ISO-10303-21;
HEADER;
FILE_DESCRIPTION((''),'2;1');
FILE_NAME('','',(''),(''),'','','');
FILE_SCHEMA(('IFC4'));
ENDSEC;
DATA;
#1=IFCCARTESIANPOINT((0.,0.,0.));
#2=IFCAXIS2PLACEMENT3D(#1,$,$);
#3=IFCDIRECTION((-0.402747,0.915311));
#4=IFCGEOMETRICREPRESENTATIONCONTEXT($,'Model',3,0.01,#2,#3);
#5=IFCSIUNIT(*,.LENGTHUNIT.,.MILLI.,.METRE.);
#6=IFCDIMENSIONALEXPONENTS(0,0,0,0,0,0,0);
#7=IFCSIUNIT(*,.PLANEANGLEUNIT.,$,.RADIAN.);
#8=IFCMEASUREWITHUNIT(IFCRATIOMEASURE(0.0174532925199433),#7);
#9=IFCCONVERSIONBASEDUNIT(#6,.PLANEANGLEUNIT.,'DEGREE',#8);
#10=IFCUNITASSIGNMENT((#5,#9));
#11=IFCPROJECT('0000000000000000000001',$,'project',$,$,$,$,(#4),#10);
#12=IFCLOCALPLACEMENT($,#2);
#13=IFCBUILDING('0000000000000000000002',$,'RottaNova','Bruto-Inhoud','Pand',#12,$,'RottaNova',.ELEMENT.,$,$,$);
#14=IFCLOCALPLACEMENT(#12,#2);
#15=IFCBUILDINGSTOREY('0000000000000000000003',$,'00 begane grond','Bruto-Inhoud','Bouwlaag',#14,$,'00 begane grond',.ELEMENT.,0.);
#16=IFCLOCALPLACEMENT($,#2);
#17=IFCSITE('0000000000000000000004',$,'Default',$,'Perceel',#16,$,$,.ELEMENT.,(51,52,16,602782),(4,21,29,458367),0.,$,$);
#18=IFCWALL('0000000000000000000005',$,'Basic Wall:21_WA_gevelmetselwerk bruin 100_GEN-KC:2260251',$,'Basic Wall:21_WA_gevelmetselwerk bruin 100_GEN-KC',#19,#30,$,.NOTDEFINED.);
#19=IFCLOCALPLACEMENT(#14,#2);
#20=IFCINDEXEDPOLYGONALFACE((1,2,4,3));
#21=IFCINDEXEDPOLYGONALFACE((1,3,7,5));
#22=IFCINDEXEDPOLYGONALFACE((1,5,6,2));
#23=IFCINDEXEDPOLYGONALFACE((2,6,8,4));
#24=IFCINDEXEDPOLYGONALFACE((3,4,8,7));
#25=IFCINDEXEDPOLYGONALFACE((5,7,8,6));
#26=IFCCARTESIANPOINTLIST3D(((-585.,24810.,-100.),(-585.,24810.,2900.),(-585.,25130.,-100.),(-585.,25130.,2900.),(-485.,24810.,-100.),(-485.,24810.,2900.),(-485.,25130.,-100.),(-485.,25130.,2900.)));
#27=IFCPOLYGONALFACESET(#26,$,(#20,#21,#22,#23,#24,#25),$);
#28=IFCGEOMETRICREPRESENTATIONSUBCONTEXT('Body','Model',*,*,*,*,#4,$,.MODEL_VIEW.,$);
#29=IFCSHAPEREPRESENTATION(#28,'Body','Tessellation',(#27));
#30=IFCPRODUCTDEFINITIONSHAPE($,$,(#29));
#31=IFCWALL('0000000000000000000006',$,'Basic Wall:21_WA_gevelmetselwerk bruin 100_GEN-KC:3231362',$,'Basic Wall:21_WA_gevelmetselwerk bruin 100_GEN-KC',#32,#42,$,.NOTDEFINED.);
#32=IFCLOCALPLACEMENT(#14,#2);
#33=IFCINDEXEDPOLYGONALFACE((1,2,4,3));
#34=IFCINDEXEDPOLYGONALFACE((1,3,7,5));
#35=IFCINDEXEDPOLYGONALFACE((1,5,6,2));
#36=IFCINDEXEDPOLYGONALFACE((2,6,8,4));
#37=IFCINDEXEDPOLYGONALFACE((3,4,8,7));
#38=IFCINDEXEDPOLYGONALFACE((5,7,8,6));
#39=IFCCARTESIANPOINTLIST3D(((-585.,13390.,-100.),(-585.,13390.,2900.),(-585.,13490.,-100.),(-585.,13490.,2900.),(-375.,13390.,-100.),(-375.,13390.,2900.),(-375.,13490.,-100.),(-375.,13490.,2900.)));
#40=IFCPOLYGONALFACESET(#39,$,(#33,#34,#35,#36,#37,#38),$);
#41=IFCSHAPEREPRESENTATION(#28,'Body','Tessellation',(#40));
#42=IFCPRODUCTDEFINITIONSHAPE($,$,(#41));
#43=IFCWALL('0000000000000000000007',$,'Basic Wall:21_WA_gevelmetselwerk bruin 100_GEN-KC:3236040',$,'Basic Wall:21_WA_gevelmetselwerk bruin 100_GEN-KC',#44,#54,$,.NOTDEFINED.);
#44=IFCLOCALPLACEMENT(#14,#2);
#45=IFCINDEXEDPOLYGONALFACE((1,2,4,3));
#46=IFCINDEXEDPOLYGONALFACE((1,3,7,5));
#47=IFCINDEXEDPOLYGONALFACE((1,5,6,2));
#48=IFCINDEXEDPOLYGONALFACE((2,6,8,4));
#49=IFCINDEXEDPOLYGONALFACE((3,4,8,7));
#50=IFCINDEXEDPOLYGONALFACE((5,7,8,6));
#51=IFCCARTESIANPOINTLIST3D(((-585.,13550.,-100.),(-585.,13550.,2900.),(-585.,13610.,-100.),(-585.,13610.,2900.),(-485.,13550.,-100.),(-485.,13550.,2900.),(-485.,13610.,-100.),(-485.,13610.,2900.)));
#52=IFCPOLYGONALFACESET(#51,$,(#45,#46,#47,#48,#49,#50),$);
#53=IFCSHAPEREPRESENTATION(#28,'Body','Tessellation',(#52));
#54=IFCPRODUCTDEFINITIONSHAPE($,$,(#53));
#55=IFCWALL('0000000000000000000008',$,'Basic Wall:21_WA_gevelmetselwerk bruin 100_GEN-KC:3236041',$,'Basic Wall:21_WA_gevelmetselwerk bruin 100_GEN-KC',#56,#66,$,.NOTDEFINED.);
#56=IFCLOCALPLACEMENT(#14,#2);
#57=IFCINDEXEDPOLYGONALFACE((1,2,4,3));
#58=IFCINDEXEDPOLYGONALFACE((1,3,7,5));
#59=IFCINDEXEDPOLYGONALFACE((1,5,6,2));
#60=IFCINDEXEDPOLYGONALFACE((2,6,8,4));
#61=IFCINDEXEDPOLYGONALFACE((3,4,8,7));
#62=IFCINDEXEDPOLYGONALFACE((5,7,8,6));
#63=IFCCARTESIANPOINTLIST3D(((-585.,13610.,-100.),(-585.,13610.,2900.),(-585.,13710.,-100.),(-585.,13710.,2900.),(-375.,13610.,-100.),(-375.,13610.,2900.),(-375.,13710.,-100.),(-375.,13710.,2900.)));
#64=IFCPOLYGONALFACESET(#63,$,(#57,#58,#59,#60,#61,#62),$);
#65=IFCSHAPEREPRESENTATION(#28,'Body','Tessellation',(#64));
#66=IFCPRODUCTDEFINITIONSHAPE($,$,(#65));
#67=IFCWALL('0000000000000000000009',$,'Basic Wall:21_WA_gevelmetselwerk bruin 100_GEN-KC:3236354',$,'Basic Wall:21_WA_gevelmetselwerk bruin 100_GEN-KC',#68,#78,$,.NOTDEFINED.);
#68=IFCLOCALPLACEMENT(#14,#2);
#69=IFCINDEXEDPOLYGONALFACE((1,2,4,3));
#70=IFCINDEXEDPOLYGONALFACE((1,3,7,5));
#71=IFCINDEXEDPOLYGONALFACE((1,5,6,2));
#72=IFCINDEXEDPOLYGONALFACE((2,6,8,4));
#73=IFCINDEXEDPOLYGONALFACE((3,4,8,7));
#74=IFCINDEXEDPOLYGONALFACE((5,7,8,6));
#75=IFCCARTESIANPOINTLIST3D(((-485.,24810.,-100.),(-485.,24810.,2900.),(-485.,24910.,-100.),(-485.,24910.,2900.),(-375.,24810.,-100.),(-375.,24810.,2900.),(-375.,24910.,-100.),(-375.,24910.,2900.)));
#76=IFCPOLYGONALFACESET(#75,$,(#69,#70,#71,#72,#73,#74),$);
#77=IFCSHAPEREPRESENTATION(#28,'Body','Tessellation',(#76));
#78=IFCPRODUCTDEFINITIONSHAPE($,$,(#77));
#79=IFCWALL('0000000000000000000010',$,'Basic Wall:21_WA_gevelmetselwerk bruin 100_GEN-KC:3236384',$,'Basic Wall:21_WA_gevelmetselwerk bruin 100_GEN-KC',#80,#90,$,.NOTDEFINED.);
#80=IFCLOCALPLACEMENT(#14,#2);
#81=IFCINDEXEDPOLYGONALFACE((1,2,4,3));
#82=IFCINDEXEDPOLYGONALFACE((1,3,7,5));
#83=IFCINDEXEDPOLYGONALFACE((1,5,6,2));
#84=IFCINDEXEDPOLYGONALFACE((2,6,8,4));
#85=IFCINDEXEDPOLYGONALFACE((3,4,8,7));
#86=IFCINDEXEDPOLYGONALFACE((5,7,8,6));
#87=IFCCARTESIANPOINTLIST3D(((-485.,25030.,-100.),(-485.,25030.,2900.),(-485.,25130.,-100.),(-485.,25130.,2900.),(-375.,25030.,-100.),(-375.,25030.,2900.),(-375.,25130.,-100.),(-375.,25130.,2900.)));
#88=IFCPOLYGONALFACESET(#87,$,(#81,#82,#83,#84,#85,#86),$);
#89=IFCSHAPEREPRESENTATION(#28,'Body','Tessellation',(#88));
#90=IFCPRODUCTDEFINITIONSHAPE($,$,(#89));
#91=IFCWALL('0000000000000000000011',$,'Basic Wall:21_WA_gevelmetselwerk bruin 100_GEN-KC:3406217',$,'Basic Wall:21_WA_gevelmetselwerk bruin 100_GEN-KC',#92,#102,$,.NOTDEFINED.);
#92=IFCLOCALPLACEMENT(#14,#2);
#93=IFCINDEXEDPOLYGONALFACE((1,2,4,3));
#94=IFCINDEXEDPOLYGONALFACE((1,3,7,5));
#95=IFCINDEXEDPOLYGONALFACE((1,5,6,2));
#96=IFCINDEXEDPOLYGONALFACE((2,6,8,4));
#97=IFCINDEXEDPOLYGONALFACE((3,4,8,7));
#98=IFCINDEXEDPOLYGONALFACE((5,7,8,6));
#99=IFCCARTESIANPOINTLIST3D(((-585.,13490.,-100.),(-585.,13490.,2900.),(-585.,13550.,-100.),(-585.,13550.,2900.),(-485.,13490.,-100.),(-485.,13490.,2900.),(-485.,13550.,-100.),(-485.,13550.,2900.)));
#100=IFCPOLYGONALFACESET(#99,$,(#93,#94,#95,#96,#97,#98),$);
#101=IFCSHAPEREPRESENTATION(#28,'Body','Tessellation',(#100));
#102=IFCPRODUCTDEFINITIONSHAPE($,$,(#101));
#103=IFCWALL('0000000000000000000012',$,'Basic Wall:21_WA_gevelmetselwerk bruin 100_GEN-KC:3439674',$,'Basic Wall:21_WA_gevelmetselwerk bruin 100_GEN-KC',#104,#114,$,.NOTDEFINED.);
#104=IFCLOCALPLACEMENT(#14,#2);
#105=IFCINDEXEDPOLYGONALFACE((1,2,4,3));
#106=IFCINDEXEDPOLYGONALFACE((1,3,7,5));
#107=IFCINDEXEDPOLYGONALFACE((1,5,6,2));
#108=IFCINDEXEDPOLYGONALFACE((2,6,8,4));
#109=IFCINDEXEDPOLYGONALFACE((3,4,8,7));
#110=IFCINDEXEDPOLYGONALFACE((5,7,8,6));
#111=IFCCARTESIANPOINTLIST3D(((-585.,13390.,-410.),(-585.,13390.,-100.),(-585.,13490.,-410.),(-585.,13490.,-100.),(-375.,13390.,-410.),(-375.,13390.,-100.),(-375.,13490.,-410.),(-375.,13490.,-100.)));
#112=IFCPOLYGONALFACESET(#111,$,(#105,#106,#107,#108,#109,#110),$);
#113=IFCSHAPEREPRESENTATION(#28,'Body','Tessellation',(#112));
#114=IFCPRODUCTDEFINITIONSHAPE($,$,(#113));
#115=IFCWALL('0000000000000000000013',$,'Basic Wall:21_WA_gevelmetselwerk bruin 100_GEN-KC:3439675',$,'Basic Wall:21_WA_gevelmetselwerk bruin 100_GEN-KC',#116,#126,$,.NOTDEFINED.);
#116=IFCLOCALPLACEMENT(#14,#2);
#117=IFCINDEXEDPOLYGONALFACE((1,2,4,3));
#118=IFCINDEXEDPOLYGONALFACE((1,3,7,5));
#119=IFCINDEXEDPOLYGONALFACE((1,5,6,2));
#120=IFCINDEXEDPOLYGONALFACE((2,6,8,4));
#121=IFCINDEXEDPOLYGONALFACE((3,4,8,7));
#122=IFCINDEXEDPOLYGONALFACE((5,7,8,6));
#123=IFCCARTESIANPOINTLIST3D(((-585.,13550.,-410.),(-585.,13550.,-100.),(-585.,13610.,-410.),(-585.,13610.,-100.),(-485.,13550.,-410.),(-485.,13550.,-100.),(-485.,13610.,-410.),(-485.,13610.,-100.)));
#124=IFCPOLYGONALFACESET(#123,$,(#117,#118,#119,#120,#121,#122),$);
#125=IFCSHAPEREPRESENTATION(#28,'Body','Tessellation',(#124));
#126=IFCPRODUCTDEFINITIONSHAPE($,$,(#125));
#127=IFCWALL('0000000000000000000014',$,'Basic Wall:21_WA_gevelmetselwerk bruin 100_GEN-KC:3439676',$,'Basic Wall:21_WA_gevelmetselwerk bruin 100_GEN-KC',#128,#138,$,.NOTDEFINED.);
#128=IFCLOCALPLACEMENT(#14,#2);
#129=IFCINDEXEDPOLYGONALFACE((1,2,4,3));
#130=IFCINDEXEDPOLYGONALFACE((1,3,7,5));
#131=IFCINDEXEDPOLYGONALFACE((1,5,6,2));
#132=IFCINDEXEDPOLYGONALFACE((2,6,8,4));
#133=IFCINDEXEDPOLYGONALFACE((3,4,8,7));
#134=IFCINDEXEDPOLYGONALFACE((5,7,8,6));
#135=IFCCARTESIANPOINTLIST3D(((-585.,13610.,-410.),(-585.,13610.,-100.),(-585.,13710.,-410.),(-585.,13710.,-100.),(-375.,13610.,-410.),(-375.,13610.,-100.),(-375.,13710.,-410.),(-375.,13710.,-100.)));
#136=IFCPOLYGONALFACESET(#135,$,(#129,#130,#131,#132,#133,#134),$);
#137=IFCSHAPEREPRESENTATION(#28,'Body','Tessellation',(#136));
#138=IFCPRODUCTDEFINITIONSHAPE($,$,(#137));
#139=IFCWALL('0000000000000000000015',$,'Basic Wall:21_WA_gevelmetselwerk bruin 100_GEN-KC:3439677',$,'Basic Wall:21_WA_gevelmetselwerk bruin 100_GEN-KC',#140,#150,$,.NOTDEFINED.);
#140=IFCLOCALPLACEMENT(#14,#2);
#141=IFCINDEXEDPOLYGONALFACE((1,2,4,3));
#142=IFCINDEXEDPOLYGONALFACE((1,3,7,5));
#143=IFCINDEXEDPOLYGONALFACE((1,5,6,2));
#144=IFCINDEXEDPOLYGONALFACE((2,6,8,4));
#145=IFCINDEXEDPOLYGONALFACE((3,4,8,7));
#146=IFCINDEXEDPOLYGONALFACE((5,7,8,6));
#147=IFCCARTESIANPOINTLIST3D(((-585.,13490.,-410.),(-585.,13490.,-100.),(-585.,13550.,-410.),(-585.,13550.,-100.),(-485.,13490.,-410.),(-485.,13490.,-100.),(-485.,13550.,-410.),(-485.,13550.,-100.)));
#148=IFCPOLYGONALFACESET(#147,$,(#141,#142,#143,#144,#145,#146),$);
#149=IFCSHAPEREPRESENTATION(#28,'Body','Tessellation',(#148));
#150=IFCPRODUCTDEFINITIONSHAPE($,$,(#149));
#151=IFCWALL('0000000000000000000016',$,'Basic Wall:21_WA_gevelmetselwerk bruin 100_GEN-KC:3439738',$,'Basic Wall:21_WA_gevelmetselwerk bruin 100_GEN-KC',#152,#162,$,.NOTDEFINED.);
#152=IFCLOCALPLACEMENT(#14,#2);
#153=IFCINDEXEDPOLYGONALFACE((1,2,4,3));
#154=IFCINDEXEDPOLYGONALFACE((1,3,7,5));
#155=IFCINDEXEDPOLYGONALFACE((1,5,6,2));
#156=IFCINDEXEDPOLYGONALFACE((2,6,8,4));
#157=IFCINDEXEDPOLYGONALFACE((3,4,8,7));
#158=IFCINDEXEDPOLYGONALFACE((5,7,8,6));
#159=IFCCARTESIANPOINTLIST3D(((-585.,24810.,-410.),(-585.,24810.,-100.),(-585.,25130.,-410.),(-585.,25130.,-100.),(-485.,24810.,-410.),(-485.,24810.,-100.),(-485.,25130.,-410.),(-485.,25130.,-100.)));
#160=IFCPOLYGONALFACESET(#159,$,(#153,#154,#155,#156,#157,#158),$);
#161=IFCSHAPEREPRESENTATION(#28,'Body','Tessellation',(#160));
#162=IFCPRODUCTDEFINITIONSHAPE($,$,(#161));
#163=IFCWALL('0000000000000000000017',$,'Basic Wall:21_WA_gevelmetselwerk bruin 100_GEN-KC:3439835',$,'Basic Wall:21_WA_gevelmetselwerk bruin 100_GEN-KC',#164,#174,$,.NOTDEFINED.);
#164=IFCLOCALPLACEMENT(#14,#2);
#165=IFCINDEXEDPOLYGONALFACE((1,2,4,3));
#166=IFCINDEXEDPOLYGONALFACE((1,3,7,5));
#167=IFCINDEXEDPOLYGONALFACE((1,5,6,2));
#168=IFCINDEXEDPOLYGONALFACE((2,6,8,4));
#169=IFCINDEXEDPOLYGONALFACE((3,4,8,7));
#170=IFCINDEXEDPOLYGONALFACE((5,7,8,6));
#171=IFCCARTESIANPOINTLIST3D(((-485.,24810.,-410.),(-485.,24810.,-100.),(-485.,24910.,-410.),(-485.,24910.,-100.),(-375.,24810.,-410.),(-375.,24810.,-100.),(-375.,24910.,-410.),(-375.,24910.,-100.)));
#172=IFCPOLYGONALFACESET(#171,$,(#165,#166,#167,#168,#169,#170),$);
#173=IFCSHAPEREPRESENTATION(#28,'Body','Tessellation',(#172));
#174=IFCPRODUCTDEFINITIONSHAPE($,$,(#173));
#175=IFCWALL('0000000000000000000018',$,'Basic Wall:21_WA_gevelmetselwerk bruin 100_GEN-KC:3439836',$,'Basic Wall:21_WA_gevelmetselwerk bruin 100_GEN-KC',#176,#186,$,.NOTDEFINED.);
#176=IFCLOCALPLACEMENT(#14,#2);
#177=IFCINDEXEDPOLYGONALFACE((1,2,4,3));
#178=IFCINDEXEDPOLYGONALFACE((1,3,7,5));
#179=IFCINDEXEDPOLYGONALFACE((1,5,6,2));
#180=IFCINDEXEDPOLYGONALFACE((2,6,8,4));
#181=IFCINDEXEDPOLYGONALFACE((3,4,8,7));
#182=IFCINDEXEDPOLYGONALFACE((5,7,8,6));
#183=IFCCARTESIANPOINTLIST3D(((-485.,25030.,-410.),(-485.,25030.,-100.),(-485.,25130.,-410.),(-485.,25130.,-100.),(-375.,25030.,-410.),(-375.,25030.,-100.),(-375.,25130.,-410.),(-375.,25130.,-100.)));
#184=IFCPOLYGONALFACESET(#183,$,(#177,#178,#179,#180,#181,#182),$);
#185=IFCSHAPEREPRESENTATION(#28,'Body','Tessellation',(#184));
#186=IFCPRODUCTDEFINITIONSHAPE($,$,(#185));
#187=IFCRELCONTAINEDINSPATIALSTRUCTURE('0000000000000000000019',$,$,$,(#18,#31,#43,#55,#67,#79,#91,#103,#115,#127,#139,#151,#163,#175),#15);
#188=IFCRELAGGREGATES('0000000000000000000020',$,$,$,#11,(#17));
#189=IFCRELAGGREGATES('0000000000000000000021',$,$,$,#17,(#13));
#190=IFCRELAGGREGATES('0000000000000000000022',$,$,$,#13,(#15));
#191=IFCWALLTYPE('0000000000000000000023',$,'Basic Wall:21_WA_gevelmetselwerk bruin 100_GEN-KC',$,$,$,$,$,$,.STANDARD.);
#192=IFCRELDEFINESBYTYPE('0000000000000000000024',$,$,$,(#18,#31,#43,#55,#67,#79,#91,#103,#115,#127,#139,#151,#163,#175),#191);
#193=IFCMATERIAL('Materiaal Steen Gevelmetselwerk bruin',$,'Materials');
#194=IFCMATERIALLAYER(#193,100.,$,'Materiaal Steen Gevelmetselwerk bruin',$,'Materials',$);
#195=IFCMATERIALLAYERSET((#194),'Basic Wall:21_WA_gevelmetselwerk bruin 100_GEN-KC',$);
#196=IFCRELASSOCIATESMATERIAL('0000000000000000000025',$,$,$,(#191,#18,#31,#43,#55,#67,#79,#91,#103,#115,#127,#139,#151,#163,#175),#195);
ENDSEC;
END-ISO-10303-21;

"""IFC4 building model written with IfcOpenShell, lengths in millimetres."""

from ifc_helpers import new_model, entity, si_unit, converted_unit, direction, frame, frame_2d, origin, place, context, subcontext, project, spatial, rectangle, extrude, material, layer, layer_set, type_object, element, save


model = new_model("IFC4")

# Units and contexts
model_context = context("Model", 3, precision=0.01, world=origin(), true_north=direction((-0.402747, 0.915311)))
body_context = subcontext(model_context, "Body", "Model", "MODEL_VIEW")
ifc_project = project(units=[si_unit("LENGTHUNIT", "METRE", prefix="MILLI"), converted_unit("PLANEANGLEUNIT", "DEGREE", entity("IfcRatioMeasure", 0.0174532925199433), si_unit("PLANEANGLEUNIT", "RADIAN"), dimensions=[0, 0, 0, 0, 0, 0, 0])], contexts=[model_context])

# Site, building, storey
site_placement = place(None, origin())
site = spatial("IfcSite", under=ifc_project, at=site_placement, Name="Default", ObjectType="Perceel", CompositionType="ELEMENT", RefLatitude=(51, 52, 16, 602782), RefLongitude=(4, 21, 29, 458367), RefElevation=0.0)
building_placement = place(None, origin())
building = spatial("IfcBuilding", under=site, at=building_placement, Name="RottaNova", Description="Bruto-Inhoud", ObjectType="Pand", LongName="RottaNova", CompositionType="ELEMENT")
storey_placement = place(building_placement, origin())
storey = spatial("IfcBuildingStorey", under=building, at=storey_placement, Name="00 begane grond", Description="Bruto-Inhoud", ObjectType="Bouwlaag", LongName="00 begane grond", CompositionType="ELEMENT", Elevation=0.0)

# Walls
ifc_material_1 = material(Name="Materiaal Steen Gevelmetselwerk bruin", Category="Materials")
ifc_layer_1 = layer(ifc_material_1, 100.0, Name="Materiaal Steen Gevelmetselwerk bruin", Category="Materials")
ifc_layer_set_1 = layer_set([ifc_layer_1], Name="Basic Wall:21_WA_gevelmetselwerk bruin 100_GEN-KC")
wall_type_1 = type_object("IfcWallType", Name="Basic Wall:21_WA_gevelmetselwerk bruin 100_GEN-KC", PredefinedType="STANDARD", material=ifc_layer_set_1)
wall_1_placement = place(storey_placement, frame((-535.0, 25130.0, -100.0), z_axis=(0.0, 0.0, 1.0), x_axis=(0.0, -1.0, 0.0)))
element("IfcWall", 1, at=wall_1_placement, inside=storey, type_object=wall_type_1, material=ifc_layer_set_1, Name="Basic Wall:21_WA_gevelmetselwerk bruin 100_GEN-KC:2260251", ObjectType="Basic Wall:21_WA_gevelmetselwerk bruin 100_GEN-KC", PredefinedType="NOTDEFINED", context=body_context, shape_type="SweptSolid", body=[
    extrude(rectangle(XDim=320.0, YDim=100.0, at=frame_2d((160.0, 0.0), x_axis=(-1.0, 0.0))), origin(), (0.0, 0.0, 1.0), 3000.0),
])
wall_2_placement = place(storey_placement, frame((-585.0, 13440.0, -100.0)))
element("IfcWall", 2, at=wall_2_placement, inside=storey, type_object=wall_type_1, material=ifc_layer_set_1, Name="Basic Wall:21_WA_gevelmetselwerk bruin 100_GEN-KC:3231362", ObjectType="Basic Wall:21_WA_gevelmetselwerk bruin 100_GEN-KC", PredefinedType="NOTDEFINED", context=body_context, shape_type="SweptSolid", body=[
    extrude(rectangle(XDim=210.0, YDim=100.0, at=frame_2d((105.0, 0.0), x_axis=(-1.0, 0.0))), origin(), (0.0, 0.0, 1.0), 3000.0),
])
wall_3_placement = place(storey_placement, frame((-535.0, 13550.0, -100.0), z_axis=(0.0, 0.0, 1.0), x_axis=(0.0, 1.0, 0.0)))
element("IfcWall", 3, at=wall_3_placement, inside=storey, type_object=wall_type_1, material=ifc_layer_set_1, Name="Basic Wall:21_WA_gevelmetselwerk bruin 100_GEN-KC:3236040", ObjectType="Basic Wall:21_WA_gevelmetselwerk bruin 100_GEN-KC", PredefinedType="NOTDEFINED", context=body_context, shape_type="SweptSolid", body=[
    extrude(rectangle(XDim=60.0, YDim=100.0, at=frame_2d((30.0, 0.0), x_axis=(-1.0, 0.0))), origin(), (0.0, 0.0, 1.0), 3000.0),
])
wall_4_placement = place(storey_placement, frame((-585.0, 13660.0, -100.0)))
element("IfcWall", 4, at=wall_4_placement, inside=storey, type_object=wall_type_1, material=ifc_layer_set_1, Name="Basic Wall:21_WA_gevelmetselwerk bruin 100_GEN-KC:3236041", ObjectType="Basic Wall:21_WA_gevelmetselwerk bruin 100_GEN-KC", PredefinedType="NOTDEFINED", context=body_context, shape_type="SweptSolid", body=[
    extrude(rectangle(XDim=210.0, YDim=100.0, at=frame_2d((105.0, 0.0), x_axis=(-1.0, 0.0))), origin(), (0.0, 0.0, 1.0), 3000.0),
])
wall_5_placement = place(storey_placement, frame((-485.0, 24860.0, -100.0)))
element("IfcWall", 5, at=wall_5_placement, inside=storey, type_object=wall_type_1, material=ifc_layer_set_1, Name="Basic Wall:21_WA_gevelmetselwerk bruin 100_GEN-KC:3236354", ObjectType="Basic Wall:21_WA_gevelmetselwerk bruin 100_GEN-KC", PredefinedType="NOTDEFINED", context=body_context, shape_type="SweptSolid", body=[
    extrude(rectangle(XDim=110.0, YDim=100.0, at=frame_2d((55.0, 0.0), x_axis=(-1.0, 0.0))), origin(), (0.0, 0.0, 1.0), 3000.0),
])
wall_6_placement = place(storey_placement, frame((-485.0, 25080.0, -100.0)))
element("IfcWall", 6, at=wall_6_placement, inside=storey, type_object=wall_type_1, material=ifc_layer_set_1, Name="Basic Wall:21_WA_gevelmetselwerk bruin 100_GEN-KC:3236384", ObjectType="Basic Wall:21_WA_gevelmetselwerk bruin 100_GEN-KC", PredefinedType="NOTDEFINED", context=body_context, shape_type="SweptSolid", body=[
    extrude(rectangle(XDim=110.0, YDim=100.0, at=frame_2d((55.0, 0.0), x_axis=(-1.0, 0.0))), origin(), (0.0, 0.0, 1.0), 3000.0),
])
wall_7_placement = place(storey_placement, frame((-535.0, 13490.0, -100.0), z_axis=(0.0, 0.0, 1.0), x_axis=(0.0, 1.0, 0.0)))
element("IfcWall", 7, at=wall_7_placement, inside=storey, type_object=wall_type_1, material=ifc_layer_set_1, Name="Basic Wall:21_WA_gevelmetselwerk bruin 100_GEN-KC:3406217", ObjectType="Basic Wall:21_WA_gevelmetselwerk bruin 100_GEN-KC", PredefinedType="NOTDEFINED", context=body_context, shape_type="SweptSolid", body=[
    extrude(rectangle(XDim=60.0, YDim=100.0, at=frame_2d((30.0, 0.0), x_axis=(-1.0, 0.0))), origin(), (0.0, 0.0, 1.0), 3000.0),
])
wall_8_placement = place(storey_placement, frame((-585.0, 13440.0, -410.0)))
element("IfcWall", 8, at=wall_8_placement, inside=storey, type_object=wall_type_1, material=ifc_layer_set_1, Name="Basic Wall:21_WA_gevelmetselwerk bruin 100_GEN-KC:3439674", ObjectType="Basic Wall:21_WA_gevelmetselwerk bruin 100_GEN-KC", PredefinedType="NOTDEFINED", context=body_context, shape_type="SweptSolid", body=[
    extrude(rectangle(XDim=210.0, YDim=100.0, at=frame_2d((105.0, 0.0), x_axis=(-1.0, 0.0))), origin(), (0.0, 0.0, 1.0), 310.0),
])
wall_9_placement = place(storey_placement, frame((-535.0, 13550.0, -410.0), z_axis=(0.0, 0.0, 1.0), x_axis=(0.0, 1.0, 0.0)))
element("IfcWall", 9, at=wall_9_placement, inside=storey, type_object=wall_type_1, material=ifc_layer_set_1, Name="Basic Wall:21_WA_gevelmetselwerk bruin 100_GEN-KC:3439675", ObjectType="Basic Wall:21_WA_gevelmetselwerk bruin 100_GEN-KC", PredefinedType="NOTDEFINED", context=body_context, shape_type="SweptSolid", body=[
    extrude(rectangle(XDim=60.0, YDim=100.0, at=frame_2d((30.0, 0.0), x_axis=(-1.0, 0.0))), origin(), (0.0, 0.0, 1.0), 310.0),
])
wall_10_placement = place(storey_placement, frame((-585.0, 13660.0, -410.0)))
element("IfcWall", 10, at=wall_10_placement, inside=storey, type_object=wall_type_1, material=ifc_layer_set_1, Name="Basic Wall:21_WA_gevelmetselwerk bruin 100_GEN-KC:3439676", ObjectType="Basic Wall:21_WA_gevelmetselwerk bruin 100_GEN-KC", PredefinedType="NOTDEFINED", context=body_context, shape_type="SweptSolid", body=[
    extrude(rectangle(XDim=210.0, YDim=100.0, at=frame_2d((105.0, 0.0), x_axis=(-1.0, 0.0))), origin(), (0.0, 0.0, 1.0), 310.0),
])
wall_11_placement = place(storey_placement, frame((-535.0, 13490.0, -410.0), z_axis=(0.0, 0.0, 1.0), x_axis=(0.0, 1.0, 0.0)))
element("IfcWall", 11, at=wall_11_placement, inside=storey, type_object=wall_type_1, material=ifc_layer_set_1, Name="Basic Wall:21_WA_gevelmetselwerk bruin 100_GEN-KC:3439677", ObjectType="Basic Wall:21_WA_gevelmetselwerk bruin 100_GEN-KC", PredefinedType="NOTDEFINED", context=body_context, shape_type="SweptSolid", body=[
    extrude(rectangle(XDim=60.0, YDim=100.0, at=frame_2d((30.0, 0.0), x_axis=(-1.0, 0.0))), origin(), (0.0, 0.0, 1.0), 310.0),
])
wall_12_placement = place(storey_placement, frame((-535.0, 25130.0, -410.0), z_axis=(0.0, 0.0, 1.0), x_axis=(0.0, -1.0, 0.0)))
element("IfcWall", 12, at=wall_12_placement, inside=storey, type_object=wall_type_1, material=ifc_layer_set_1, Name="Basic Wall:21_WA_gevelmetselwerk bruin 100_GEN-KC:3439738", ObjectType="Basic Wall:21_WA_gevelmetselwerk bruin 100_GEN-KC", PredefinedType="NOTDEFINED", context=body_context, shape_type="SweptSolid", body=[
    extrude(rectangle(XDim=320.0, YDim=100.0, at=frame_2d((160.0, 0.0), x_axis=(-1.0, 0.0))), origin(), (0.0, 0.0, 1.0), 310.0),
])
wall_13_placement = place(storey_placement, frame((-485.0, 24860.0, -410.0)))
element("IfcWall", 13, at=wall_13_placement, inside=storey, type_object=wall_type_1, material=ifc_layer_set_1, Name="Basic Wall:21_WA_gevelmetselwerk bruin 100_GEN-KC:3439835", ObjectType="Basic Wall:21_WA_gevelmetselwerk bruin 100_GEN-KC", PredefinedType="NOTDEFINED", context=body_context, shape_type="SweptSolid", body=[
    extrude(rectangle(XDim=110.0, YDim=100.0, at=frame_2d((55.0, 0.0), x_axis=(-1.0, 0.0))), origin(), (0.0, 0.0, 1.0), 310.0),
])
wall_14_placement = place(storey_placement, frame((-485.0, 25080.0, -410.0)))
element("IfcWall", 14, at=wall_14_placement, inside=storey, type_object=wall_type_1, material=ifc_layer_set_1, Name="Basic Wall:21_WA_gevelmetselwerk bruin 100_GEN-KC:3439836", ObjectType="Basic Wall:21_WA_gevelmetselwerk bruin 100_GEN-KC", PredefinedType="NOTDEFINED", context=body_context, shape_type="SweptSolid", body=[
    extrude(rectangle(XDim=110.0, YDim=100.0, at=frame_2d((55.0, 0.0), x_axis=(-1.0, 0.0))), origin(), (0.0, 0.0, 1.0), 310.0),
])

save(model, "model.ifc")
